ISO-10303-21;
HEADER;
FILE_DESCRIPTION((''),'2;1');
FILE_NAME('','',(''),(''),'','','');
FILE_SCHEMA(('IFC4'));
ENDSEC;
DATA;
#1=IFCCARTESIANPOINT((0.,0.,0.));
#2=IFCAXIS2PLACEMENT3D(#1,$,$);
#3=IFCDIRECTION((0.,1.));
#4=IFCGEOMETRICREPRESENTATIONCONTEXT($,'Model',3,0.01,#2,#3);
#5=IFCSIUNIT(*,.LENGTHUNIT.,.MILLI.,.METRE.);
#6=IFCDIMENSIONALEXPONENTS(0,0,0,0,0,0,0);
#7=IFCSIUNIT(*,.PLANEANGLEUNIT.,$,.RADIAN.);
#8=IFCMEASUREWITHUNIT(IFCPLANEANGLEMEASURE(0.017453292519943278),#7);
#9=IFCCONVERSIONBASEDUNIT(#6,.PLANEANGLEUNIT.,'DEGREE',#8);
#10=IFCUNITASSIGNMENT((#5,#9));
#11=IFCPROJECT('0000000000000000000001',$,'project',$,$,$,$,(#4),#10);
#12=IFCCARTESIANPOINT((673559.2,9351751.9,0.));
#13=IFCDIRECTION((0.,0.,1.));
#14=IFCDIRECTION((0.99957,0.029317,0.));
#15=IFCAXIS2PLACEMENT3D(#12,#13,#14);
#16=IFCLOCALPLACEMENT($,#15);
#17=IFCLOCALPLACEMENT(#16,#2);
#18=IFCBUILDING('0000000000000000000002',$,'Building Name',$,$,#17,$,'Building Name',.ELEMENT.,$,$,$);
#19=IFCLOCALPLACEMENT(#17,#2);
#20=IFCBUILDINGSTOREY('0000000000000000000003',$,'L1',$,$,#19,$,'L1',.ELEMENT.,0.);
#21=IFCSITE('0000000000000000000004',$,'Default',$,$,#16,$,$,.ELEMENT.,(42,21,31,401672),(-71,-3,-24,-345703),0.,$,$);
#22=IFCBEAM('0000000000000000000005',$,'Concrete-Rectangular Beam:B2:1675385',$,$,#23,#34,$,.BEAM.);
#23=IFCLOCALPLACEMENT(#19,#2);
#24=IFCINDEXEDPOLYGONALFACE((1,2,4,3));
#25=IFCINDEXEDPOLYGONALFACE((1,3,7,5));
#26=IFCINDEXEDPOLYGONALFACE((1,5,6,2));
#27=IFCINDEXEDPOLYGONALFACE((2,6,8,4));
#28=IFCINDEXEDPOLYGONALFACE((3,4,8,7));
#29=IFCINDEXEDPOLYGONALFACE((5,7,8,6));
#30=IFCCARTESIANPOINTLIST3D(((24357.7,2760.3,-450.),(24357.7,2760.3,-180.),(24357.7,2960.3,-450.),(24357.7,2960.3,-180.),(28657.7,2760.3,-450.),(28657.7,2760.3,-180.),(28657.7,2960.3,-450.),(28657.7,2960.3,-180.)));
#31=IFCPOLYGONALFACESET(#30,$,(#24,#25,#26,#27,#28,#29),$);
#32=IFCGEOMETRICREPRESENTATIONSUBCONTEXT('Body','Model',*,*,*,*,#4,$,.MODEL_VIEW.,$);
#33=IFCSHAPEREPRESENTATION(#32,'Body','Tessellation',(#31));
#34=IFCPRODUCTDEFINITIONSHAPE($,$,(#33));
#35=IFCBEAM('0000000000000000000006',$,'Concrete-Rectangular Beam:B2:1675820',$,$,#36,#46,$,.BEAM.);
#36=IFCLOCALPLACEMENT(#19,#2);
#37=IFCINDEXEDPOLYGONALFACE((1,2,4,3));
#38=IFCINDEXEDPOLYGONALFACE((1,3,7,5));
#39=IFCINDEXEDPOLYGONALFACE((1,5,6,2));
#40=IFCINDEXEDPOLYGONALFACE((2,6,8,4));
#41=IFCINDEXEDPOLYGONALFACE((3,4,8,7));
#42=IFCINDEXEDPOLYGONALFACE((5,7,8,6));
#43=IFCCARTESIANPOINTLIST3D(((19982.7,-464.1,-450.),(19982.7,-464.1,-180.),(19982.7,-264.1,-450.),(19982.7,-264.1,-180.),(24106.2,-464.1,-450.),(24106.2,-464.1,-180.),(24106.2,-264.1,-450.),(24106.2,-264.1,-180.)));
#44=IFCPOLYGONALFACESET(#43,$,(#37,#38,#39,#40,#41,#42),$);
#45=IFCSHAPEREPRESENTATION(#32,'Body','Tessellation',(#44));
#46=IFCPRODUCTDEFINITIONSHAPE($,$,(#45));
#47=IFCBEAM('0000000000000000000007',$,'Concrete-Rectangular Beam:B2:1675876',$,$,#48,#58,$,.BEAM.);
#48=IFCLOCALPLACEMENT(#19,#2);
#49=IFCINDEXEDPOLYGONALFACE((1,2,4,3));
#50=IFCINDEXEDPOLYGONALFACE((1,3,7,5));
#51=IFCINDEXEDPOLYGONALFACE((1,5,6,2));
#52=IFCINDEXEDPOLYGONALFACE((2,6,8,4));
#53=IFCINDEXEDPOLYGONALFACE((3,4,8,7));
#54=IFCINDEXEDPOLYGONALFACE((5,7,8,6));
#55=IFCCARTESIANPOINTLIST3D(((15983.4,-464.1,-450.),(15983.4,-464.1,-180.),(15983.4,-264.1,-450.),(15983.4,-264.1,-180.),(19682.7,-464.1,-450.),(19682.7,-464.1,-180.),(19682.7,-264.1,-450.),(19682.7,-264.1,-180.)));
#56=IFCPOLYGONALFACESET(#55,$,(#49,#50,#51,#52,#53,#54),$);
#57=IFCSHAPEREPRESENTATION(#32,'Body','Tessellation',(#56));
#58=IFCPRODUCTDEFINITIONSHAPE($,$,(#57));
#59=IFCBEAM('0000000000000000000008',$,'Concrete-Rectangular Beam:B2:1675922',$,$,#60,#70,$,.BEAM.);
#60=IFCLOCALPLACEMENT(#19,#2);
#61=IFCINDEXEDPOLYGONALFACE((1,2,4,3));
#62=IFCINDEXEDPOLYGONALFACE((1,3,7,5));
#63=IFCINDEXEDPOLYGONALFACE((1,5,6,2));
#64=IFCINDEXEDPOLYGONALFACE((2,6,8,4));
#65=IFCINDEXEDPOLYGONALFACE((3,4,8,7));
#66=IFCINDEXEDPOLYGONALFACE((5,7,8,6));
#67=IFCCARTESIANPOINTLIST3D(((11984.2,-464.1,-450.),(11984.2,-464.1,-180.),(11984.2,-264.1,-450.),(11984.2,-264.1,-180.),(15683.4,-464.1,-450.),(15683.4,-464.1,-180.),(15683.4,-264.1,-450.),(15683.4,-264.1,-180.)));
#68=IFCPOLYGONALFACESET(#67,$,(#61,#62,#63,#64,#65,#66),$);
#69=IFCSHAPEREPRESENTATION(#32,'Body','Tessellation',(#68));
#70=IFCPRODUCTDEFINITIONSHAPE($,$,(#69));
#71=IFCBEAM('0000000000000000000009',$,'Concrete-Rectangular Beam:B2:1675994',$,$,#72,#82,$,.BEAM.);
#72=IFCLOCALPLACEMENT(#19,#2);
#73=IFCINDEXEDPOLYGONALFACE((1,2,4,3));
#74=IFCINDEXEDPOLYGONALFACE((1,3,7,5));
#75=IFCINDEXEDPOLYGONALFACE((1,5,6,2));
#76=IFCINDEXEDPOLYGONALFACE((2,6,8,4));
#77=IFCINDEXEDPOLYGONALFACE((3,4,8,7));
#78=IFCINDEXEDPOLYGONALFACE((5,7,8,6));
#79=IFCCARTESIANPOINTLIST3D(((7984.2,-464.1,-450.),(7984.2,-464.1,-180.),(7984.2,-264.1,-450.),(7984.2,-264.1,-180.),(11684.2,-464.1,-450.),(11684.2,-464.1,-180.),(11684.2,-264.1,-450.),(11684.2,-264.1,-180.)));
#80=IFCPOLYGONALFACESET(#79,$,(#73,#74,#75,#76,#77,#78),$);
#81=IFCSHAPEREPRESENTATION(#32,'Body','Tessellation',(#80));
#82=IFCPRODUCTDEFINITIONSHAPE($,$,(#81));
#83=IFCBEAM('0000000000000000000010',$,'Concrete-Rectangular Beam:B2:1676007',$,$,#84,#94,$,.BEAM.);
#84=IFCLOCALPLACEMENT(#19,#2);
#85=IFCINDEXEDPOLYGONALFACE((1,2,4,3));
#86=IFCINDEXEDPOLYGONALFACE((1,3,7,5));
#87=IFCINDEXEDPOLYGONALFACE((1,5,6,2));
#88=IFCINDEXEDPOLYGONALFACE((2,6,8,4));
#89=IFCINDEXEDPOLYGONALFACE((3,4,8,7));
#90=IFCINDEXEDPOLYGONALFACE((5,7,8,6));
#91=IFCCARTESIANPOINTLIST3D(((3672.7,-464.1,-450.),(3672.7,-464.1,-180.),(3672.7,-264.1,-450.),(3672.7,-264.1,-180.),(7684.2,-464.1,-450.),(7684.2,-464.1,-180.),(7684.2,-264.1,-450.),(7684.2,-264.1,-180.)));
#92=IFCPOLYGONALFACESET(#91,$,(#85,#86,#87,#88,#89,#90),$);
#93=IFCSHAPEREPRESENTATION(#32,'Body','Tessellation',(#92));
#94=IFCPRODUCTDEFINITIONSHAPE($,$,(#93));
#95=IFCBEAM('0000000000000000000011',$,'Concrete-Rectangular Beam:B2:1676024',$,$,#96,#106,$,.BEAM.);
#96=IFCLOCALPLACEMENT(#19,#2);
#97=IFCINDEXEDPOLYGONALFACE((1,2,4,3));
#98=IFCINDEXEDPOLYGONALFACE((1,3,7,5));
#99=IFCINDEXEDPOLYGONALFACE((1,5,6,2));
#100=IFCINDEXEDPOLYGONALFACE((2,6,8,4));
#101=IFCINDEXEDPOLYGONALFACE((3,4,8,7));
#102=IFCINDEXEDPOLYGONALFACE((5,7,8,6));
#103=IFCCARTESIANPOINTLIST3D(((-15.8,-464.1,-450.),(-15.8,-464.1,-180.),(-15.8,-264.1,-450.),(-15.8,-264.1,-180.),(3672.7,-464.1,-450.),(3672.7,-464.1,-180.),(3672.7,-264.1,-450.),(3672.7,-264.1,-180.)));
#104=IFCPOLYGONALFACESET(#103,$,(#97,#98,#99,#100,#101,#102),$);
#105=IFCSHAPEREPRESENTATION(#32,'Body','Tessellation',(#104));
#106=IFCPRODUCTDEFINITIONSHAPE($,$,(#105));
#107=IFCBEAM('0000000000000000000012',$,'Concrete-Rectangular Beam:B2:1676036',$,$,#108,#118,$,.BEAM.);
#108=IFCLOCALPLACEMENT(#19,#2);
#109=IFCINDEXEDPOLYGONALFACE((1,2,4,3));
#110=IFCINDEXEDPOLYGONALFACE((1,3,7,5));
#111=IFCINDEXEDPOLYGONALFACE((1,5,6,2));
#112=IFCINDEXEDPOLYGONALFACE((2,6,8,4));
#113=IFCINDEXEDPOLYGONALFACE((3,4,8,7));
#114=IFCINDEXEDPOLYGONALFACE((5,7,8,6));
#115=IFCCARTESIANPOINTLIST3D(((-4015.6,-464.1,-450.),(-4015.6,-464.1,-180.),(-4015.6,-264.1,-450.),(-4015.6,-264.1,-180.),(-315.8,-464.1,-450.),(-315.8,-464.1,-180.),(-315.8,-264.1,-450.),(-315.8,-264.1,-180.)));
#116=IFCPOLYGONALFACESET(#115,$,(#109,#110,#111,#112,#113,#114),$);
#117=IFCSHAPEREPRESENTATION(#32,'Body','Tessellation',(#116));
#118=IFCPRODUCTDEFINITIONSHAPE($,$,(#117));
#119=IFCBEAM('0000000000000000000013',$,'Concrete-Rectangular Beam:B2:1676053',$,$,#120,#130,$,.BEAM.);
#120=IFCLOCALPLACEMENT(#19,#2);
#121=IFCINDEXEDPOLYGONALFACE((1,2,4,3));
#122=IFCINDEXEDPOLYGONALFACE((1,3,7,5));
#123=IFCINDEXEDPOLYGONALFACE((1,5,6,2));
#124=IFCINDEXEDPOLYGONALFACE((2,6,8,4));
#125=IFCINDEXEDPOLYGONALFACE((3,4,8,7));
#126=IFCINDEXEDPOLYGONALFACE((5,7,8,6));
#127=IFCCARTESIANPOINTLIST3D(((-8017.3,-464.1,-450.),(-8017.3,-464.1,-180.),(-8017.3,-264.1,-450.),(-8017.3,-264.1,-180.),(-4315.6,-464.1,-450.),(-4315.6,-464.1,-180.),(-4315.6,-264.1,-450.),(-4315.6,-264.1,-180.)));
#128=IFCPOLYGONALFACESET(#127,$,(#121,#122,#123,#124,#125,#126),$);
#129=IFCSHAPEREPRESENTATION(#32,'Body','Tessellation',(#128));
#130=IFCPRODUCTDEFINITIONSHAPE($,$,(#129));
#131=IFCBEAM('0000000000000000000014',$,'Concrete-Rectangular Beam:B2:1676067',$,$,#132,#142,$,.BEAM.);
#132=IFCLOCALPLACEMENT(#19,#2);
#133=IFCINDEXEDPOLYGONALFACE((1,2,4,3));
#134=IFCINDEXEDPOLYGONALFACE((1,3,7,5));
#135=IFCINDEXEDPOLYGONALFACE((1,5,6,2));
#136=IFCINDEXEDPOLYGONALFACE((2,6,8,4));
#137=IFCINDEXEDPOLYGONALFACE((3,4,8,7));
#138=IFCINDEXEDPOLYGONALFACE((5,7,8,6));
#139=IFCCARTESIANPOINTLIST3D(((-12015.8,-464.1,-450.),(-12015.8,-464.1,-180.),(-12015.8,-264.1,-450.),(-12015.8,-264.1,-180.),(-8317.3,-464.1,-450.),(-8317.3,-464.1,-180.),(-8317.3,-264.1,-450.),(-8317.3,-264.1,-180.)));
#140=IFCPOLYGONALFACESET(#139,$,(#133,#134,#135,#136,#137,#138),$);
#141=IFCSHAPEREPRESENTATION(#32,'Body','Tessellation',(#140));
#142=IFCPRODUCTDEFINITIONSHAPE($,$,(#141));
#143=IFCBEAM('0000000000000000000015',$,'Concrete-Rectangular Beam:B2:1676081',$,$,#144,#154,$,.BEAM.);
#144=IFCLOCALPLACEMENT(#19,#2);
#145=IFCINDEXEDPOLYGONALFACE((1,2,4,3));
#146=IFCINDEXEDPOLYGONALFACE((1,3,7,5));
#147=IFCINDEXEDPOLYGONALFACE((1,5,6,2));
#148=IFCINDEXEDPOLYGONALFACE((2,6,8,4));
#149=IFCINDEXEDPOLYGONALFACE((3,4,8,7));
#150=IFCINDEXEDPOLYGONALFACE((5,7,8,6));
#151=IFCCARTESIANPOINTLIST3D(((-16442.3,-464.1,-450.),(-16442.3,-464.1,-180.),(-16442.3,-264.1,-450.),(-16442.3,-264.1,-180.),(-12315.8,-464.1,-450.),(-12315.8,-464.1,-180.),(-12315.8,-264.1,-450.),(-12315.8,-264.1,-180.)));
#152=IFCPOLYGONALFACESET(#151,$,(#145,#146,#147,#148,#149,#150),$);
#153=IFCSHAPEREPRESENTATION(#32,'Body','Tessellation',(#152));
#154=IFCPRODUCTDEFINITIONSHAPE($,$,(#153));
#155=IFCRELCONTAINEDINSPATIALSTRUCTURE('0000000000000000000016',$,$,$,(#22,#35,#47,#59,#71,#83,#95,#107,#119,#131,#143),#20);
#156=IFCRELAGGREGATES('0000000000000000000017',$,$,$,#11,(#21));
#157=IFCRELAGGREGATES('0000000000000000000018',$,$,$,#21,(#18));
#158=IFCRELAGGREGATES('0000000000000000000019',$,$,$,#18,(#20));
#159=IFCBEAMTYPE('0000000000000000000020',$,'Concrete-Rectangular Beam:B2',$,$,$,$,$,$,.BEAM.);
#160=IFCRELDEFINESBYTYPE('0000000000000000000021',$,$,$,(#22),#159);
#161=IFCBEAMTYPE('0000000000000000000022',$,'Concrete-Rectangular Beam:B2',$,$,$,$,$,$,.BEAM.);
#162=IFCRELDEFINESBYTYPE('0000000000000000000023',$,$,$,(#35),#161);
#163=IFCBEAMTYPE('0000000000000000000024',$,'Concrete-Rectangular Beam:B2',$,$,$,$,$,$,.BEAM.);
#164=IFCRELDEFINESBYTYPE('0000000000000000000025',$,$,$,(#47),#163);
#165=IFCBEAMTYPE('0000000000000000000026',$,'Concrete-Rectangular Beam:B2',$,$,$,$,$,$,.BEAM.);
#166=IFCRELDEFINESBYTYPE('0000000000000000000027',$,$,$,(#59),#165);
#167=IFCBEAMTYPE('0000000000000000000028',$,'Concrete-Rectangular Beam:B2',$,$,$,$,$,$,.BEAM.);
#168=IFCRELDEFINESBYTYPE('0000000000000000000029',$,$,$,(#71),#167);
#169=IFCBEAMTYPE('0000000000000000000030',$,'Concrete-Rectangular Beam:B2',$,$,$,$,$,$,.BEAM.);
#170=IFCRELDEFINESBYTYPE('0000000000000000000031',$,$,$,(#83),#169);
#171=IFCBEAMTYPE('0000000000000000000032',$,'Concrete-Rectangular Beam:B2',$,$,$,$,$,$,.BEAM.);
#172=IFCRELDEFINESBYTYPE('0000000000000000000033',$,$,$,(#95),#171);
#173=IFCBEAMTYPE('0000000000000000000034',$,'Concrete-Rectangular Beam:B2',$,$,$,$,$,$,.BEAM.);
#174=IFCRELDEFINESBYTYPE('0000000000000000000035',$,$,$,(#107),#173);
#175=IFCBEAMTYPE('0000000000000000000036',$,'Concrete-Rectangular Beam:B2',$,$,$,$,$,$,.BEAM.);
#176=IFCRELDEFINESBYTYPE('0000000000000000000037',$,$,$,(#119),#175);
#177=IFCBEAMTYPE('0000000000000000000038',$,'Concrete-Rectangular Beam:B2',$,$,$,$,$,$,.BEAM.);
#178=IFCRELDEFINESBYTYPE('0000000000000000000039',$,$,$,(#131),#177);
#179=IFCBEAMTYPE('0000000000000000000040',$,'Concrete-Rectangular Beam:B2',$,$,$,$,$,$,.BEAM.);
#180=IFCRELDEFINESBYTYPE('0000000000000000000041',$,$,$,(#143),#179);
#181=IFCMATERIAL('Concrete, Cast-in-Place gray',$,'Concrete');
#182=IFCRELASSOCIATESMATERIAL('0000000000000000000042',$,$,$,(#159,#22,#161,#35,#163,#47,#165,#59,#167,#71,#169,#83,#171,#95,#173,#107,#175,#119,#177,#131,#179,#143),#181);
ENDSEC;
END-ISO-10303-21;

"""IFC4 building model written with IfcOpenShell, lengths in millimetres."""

from ifc_helpers import new_model, entity, si_unit, converted_unit, direction, frame, origin, place, context, subcontext, project, spatial, indexed_curve, outline, extrude, source, transform, mapped, material, type_object, type_shapes, element, save


model = new_model("IFC4")

# Units and contexts
model_context = context("Model", 3, precision=0.01, world=origin(), true_north=direction((0.0, 1.0)))
body_context = subcontext(model_context, "Body", "Model", "MODEL_VIEW")
ifc_project = project(units=[si_unit("LENGTHUNIT", "METRE", prefix="MILLI"), converted_unit("PLANEANGLEUNIT", "DEGREE", entity("IfcPlaneAngleMeasure", 0.017453292519943278), si_unit("PLANEANGLEUNIT", "RADIAN"), dimensions=[0, 0, 0, 0, 0, 0, 0])], contexts=[model_context])

# Site, building, storey
site_placement = place(None, frame((673559.2, 9351751.9, 0.0), z_axis=(0.0, 0.0, 1.0), x_axis=(0.99957, 0.029317, 0.0)))
site = spatial("IfcSite", under=ifc_project, at=site_placement, Name="Default", CompositionType="ELEMENT", RefLatitude=(42, 21, 31, 401672), RefLongitude=(-71, -3, -24, -345703), RefElevation=0.0)
building_placement = place(site_placement, origin())
building = spatial("IfcBuilding", under=site, at=building_placement, Name="Building Name", LongName="Building Name", CompositionType="ELEMENT")
storey_placement = place(building_placement, origin())
storey = spatial("IfcBuildingStorey", under=building, at=storey_placement, Name="L1", LongName="L1", CompositionType="ELEMENT", Elevation=0.0)

# Beams
ifc_material = material(Name="Concrete, Cast-in-Place gray", Category="Concrete")
beam_type_1 = type_object("IfcBeamType", Name="Concrete-Rectangular Beam:B2", PredefinedType="BEAM", material=ifc_material)
shared_shape_1 = source(origin(), body_context, "Body", "SweptSolid", [
    extrude(outline(indexed_curve([(-135.0, -100.0), (135.0, -100.0), (135.0, 100.0), (-135.0, 100.0), (-135.0, -100.0)], self_intersect=False)), frame((24357.7, 2860.3, -315.0), z_axis=(1.0, 0.0, 0.0), x_axis=(0.0, 0.0, -1.0)), (0.0, 0.0, 1.0), 4300.0),
])
type_shapes(beam_type_1, [shared_shape_1])
beam_1_placement = place(storey_placement, origin())
element("IfcBeam", 1, at=beam_1_placement, inside=storey, type_object=beam_type_1, material=ifc_material, Name="Concrete-Rectangular Beam:B2:1675385", PredefinedType="BEAM", context=body_context, shape_type="MappedRepresentation", body=[
    mapped(shared_shape_1, transform((0.0, 0.0, 0.0), scale=1.0)),
])
beam_type_2 = type_object("IfcBeamType", Name="Concrete-Rectangular Beam:B2", PredefinedType="BEAM", material=ifc_material)
shared_shape_2 = source(origin(), body_context, "Body", "SweptSolid", [
    extrude(outline(indexed_curve([(-135.0, -100.0), (135.0, -100.0), (135.0, 100.0), (-135.0, 100.0), (-135.0, -100.0)], self_intersect=False)), frame((24106.2, -364.1, -315.0), z_axis=(-1.0, 0.0, 0.0), x_axis=(0.0, 0.0, -1.0)), (0.0, 0.0, 1.0), 4123.5),
])
type_shapes(beam_type_2, [shared_shape_2])
beam_2_placement = place(storey_placement, origin())
element("IfcBeam", 2, at=beam_2_placement, inside=storey, type_object=beam_type_2, material=ifc_material, Name="Concrete-Rectangular Beam:B2:1675820", PredefinedType="BEAM", context=body_context, shape_type="MappedRepresentation", body=[
    mapped(shared_shape_2, transform((0.0, 0.0, 0.0), scale=1.0)),
])
beam_type_3 = type_object("IfcBeamType", Name="Concrete-Rectangular Beam:B2", PredefinedType="BEAM", material=ifc_material)
shared_shape_3 = source(origin(), body_context, "Body", "SweptSolid", [
    extrude(outline(indexed_curve([(-135.0, -100.0), (135.0, -100.0), (135.0, 100.0), (-135.0, 100.0), (-135.0, -100.0)], self_intersect=False)), frame((19682.7, -364.1, -315.0), z_axis=(-1.0, 0.0, 0.0), x_axis=(0.0, 0.0, -1.0)), (0.0, 0.0, 1.0), 3699.3),
])
type_shapes(beam_type_3, [shared_shape_3])
beam_3_placement = place(storey_placement, origin())
element("IfcBeam", 3, at=beam_3_placement, inside=storey, type_object=beam_type_3, material=ifc_material, Name="Concrete-Rectangular Beam:B2:1675876", PredefinedType="BEAM", context=body_context, shape_type="MappedRepresentation", body=[
    mapped(shared_shape_3, transform((0.0, 0.0, 0.0), scale=1.0)),
])
beam_type_4 = type_object("IfcBeamType", Name="Concrete-Rectangular Beam:B2", PredefinedType="BEAM", material=ifc_material)
shared_shape_4 = source(origin(), body_context, "Body", "SweptSolid", [
    extrude(outline(indexed_curve([(-135.0, -100.0), (135.0, -100.0), (135.0, 100.0), (-135.0, 100.0), (-135.0, -100.0)], self_intersect=False)), frame((11984.2, -364.1, -315.0), z_axis=(1.0, 0.0, 0.0), x_axis=(0.0, 0.0, -1.0)), (0.0, 0.0, 1.0), 3699.3),
])
type_shapes(beam_type_4, [shared_shape_4])
beam_4_placement = place(storey_placement, origin())
element("IfcBeam", 4, at=beam_4_placement, inside=storey, type_object=beam_type_4, material=ifc_material, Name="Concrete-Rectangular Beam:B2:1675922", PredefinedType="BEAM", context=body_context, shape_type="MappedRepresentation", body=[
    mapped(shared_shape_4, transform((0.0, 0.0, 0.0), scale=1.0)),
])
beam_type_5 = type_object("IfcBeamType", Name="Concrete-Rectangular Beam:B2", PredefinedType="BEAM", material=ifc_material)
shared_shape_5 = source(origin(), body_context, "Body", "SweptSolid", [
    extrude(outline(indexed_curve([(-135.0, -100.0), (135.0, -100.0), (135.0, 100.0), (-135.0, 100.0), (-135.0, -100.0)], self_intersect=False)), frame((11684.2, -364.1, -315.0), z_axis=(-1.0, 0.0, 0.0), x_axis=(0.0, 0.0, -1.0)), (0.0, 0.0, 1.0), 3700.0),
])
type_shapes(beam_type_5, [shared_shape_5])
beam_5_placement = place(storey_placement, origin())
element("IfcBeam", 5, at=beam_5_placement, inside=storey, type_object=beam_type_5, material=ifc_material, Name="Concrete-Rectangular Beam:B2:1675994", PredefinedType="BEAM", context=body_context, shape_type="MappedRepresentation", body=[
    mapped(shared_shape_5, transform((0.0, 0.0, 0.0), scale=1.0)),
])
beam_type_6 = type_object("IfcBeamType", Name="Concrete-Rectangular Beam:B2", PredefinedType="BEAM", material=ifc_material)
shared_shape_6 = source(origin(), body_context, "Body", "SweptSolid", [
    extrude(outline(indexed_curve([(-135.0, -100.0), (135.0, -100.0), (135.0, 100.0), (-135.0, 100.0), (-135.0, -100.0)], self_intersect=False)), frame((7684.2, -364.1, -315.0), z_axis=(-1.0, 0.0, 0.0), x_axis=(0.0, 0.0, -1.0)), (0.0, 0.0, 1.0), 4011.4),
])
type_shapes(beam_type_6, [shared_shape_6])
beam_6_placement = place(storey_placement, origin())
element("IfcBeam", 6, at=beam_6_placement, inside=storey, type_object=beam_type_6, material=ifc_material, Name="Concrete-Rectangular Beam:B2:1676007", PredefinedType="BEAM", context=body_context, shape_type="MappedRepresentation", body=[
    mapped(shared_shape_6, transform((0.0, 0.0, 0.0), scale=1.0)),
])
beam_type_7 = type_object("IfcBeamType", Name="Concrete-Rectangular Beam:B2", PredefinedType="BEAM", material=ifc_material)
shared_shape_7 = source(origin(), body_context, "Body", "SweptSolid", [
    extrude(outline(indexed_curve([(-135.0, -100.0), (135.0, -100.0), (135.0, 100.0), (-135.0, 100.0), (-135.0, -100.0)], self_intersect=False)), frame((3672.7, -364.1, -315.0), z_axis=(-1.0, 0.0, 0.0), x_axis=(0.0, 0.0, -1.0)), (0.0, 0.0, 1.0), 3688.6),
])
type_shapes(beam_type_7, [shared_shape_7])
beam_7_placement = place(storey_placement, origin())
element("IfcBeam", 7, at=beam_7_placement, inside=storey, type_object=beam_type_7, material=ifc_material, Name="Concrete-Rectangular Beam:B2:1676024", PredefinedType="BEAM", context=body_context, shape_type="MappedRepresentation", body=[
    mapped(shared_shape_7, transform((0.0, 0.0, 0.0), scale=1.0)),
])
beam_type_8 = type_object("IfcBeamType", Name="Concrete-Rectangular Beam:B2", PredefinedType="BEAM", material=ifc_material)
shared_shape_8 = source(origin(), body_context, "Body", "SweptSolid", [
    extrude(outline(indexed_curve([(-135.0, -100.0), (135.0, -100.0), (135.0, 100.0), (-135.0, 100.0), (-135.0, -100.0)], self_intersect=False)), frame((-315.8, -364.1, -315.0), z_axis=(-1.0, 0.0, 0.0), x_axis=(0.0, 0.0, -1.0)), (0.0, 0.0, 1.0), 3699.7),
])
type_shapes(beam_type_8, [shared_shape_8])
beam_8_placement = place(storey_placement, origin())
element("IfcBeam", 8, at=beam_8_placement, inside=storey, type_object=beam_type_8, material=ifc_material, Name="Concrete-Rectangular Beam:B2:1676036", PredefinedType="BEAM", context=body_context, shape_type="MappedRepresentation", body=[
    mapped(shared_shape_8, transform((0.0, 0.0, 0.0), scale=1.0)),
])
beam_type_9 = type_object("IfcBeamType", Name="Concrete-Rectangular Beam:B2", PredefinedType="BEAM", material=ifc_material)
shared_shape_9 = source(origin(), body_context, "Body", "SweptSolid", [
    extrude(outline(indexed_curve([(-135.0, -100.0), (135.0, -100.0), (135.0, 100.0), (-135.0, 100.0), (-135.0, -100.0)], self_intersect=False)), frame((-4315.6, -364.1, -315.0), z_axis=(-1.0, 0.0, 0.0), x_axis=(0.0, 0.0, -1.0)), (0.0, 0.0, 1.0), 3701.8),
])
type_shapes(beam_type_9, [shared_shape_9])
beam_9_placement = place(storey_placement, origin())
element("IfcBeam", 9, at=beam_9_placement, inside=storey, type_object=beam_type_9, material=ifc_material, Name="Concrete-Rectangular Beam:B2:1676053", PredefinedType="BEAM", context=body_context, shape_type="MappedRepresentation", body=[
    mapped(shared_shape_9, transform((0.0, 0.0, 0.0), scale=1.0)),
])
beam_type_10 = type_object("IfcBeamType", Name="Concrete-Rectangular Beam:B2", PredefinedType="BEAM", material=ifc_material)
shared_shape_10 = source(origin(), body_context, "Body", "SweptSolid", [
    extrude(outline(indexed_curve([(-135.0, -100.0), (135.0, -100.0), (135.0, 100.0), (-135.0, 100.0), (-135.0, -100.0)], self_intersect=False)), frame((-8317.3, -364.1, -315.0), z_axis=(-1.0, 0.0, 0.0), x_axis=(0.0, 0.0, -1.0)), (0.0, 0.0, 1.0), 3698.5),
])
type_shapes(beam_type_10, [shared_shape_10])
beam_10_placement = place(storey_placement, origin())
element("IfcBeam", 10, at=beam_10_placement, inside=storey, type_object=beam_type_10, material=ifc_material, Name="Concrete-Rectangular Beam:B2:1676067", PredefinedType="BEAM", context=body_context, shape_type="MappedRepresentation", body=[
    mapped(shared_shape_10, transform((0.0, 0.0, 0.0), scale=1.0)),
])
beam_type_11 = type_object("IfcBeamType", Name="Concrete-Rectangular Beam:B2", PredefinedType="BEAM", material=ifc_material)
shared_shape_11 = source(origin(), body_context, "Body", "SweptSolid", [
    extrude(outline(indexed_curve([(-135.0, -100.0), (135.0, -100.0), (135.0, 100.0), (-135.0, 100.0), (-135.0, -100.0)], self_intersect=False)), frame((-12315.8, -364.1, -315.0), z_axis=(-1.0, 0.0, 0.0), x_axis=(0.0, 0.0, -1.0)), (0.0, 0.0, 1.0), 4126.5),
])
type_shapes(beam_type_11, [shared_shape_11])
beam_11_placement = place(storey_placement, origin())
element("IfcBeam", 11, at=beam_11_placement, inside=storey, type_object=beam_type_11, material=ifc_material, Name="Concrete-Rectangular Beam:B2:1676081", PredefinedType="BEAM", context=body_context, shape_type="MappedRepresentation", body=[
    mapped(shared_shape_11, transform((0.0, 0.0, 0.0), scale=1.0)),
])

save(model, "model.ifc")
